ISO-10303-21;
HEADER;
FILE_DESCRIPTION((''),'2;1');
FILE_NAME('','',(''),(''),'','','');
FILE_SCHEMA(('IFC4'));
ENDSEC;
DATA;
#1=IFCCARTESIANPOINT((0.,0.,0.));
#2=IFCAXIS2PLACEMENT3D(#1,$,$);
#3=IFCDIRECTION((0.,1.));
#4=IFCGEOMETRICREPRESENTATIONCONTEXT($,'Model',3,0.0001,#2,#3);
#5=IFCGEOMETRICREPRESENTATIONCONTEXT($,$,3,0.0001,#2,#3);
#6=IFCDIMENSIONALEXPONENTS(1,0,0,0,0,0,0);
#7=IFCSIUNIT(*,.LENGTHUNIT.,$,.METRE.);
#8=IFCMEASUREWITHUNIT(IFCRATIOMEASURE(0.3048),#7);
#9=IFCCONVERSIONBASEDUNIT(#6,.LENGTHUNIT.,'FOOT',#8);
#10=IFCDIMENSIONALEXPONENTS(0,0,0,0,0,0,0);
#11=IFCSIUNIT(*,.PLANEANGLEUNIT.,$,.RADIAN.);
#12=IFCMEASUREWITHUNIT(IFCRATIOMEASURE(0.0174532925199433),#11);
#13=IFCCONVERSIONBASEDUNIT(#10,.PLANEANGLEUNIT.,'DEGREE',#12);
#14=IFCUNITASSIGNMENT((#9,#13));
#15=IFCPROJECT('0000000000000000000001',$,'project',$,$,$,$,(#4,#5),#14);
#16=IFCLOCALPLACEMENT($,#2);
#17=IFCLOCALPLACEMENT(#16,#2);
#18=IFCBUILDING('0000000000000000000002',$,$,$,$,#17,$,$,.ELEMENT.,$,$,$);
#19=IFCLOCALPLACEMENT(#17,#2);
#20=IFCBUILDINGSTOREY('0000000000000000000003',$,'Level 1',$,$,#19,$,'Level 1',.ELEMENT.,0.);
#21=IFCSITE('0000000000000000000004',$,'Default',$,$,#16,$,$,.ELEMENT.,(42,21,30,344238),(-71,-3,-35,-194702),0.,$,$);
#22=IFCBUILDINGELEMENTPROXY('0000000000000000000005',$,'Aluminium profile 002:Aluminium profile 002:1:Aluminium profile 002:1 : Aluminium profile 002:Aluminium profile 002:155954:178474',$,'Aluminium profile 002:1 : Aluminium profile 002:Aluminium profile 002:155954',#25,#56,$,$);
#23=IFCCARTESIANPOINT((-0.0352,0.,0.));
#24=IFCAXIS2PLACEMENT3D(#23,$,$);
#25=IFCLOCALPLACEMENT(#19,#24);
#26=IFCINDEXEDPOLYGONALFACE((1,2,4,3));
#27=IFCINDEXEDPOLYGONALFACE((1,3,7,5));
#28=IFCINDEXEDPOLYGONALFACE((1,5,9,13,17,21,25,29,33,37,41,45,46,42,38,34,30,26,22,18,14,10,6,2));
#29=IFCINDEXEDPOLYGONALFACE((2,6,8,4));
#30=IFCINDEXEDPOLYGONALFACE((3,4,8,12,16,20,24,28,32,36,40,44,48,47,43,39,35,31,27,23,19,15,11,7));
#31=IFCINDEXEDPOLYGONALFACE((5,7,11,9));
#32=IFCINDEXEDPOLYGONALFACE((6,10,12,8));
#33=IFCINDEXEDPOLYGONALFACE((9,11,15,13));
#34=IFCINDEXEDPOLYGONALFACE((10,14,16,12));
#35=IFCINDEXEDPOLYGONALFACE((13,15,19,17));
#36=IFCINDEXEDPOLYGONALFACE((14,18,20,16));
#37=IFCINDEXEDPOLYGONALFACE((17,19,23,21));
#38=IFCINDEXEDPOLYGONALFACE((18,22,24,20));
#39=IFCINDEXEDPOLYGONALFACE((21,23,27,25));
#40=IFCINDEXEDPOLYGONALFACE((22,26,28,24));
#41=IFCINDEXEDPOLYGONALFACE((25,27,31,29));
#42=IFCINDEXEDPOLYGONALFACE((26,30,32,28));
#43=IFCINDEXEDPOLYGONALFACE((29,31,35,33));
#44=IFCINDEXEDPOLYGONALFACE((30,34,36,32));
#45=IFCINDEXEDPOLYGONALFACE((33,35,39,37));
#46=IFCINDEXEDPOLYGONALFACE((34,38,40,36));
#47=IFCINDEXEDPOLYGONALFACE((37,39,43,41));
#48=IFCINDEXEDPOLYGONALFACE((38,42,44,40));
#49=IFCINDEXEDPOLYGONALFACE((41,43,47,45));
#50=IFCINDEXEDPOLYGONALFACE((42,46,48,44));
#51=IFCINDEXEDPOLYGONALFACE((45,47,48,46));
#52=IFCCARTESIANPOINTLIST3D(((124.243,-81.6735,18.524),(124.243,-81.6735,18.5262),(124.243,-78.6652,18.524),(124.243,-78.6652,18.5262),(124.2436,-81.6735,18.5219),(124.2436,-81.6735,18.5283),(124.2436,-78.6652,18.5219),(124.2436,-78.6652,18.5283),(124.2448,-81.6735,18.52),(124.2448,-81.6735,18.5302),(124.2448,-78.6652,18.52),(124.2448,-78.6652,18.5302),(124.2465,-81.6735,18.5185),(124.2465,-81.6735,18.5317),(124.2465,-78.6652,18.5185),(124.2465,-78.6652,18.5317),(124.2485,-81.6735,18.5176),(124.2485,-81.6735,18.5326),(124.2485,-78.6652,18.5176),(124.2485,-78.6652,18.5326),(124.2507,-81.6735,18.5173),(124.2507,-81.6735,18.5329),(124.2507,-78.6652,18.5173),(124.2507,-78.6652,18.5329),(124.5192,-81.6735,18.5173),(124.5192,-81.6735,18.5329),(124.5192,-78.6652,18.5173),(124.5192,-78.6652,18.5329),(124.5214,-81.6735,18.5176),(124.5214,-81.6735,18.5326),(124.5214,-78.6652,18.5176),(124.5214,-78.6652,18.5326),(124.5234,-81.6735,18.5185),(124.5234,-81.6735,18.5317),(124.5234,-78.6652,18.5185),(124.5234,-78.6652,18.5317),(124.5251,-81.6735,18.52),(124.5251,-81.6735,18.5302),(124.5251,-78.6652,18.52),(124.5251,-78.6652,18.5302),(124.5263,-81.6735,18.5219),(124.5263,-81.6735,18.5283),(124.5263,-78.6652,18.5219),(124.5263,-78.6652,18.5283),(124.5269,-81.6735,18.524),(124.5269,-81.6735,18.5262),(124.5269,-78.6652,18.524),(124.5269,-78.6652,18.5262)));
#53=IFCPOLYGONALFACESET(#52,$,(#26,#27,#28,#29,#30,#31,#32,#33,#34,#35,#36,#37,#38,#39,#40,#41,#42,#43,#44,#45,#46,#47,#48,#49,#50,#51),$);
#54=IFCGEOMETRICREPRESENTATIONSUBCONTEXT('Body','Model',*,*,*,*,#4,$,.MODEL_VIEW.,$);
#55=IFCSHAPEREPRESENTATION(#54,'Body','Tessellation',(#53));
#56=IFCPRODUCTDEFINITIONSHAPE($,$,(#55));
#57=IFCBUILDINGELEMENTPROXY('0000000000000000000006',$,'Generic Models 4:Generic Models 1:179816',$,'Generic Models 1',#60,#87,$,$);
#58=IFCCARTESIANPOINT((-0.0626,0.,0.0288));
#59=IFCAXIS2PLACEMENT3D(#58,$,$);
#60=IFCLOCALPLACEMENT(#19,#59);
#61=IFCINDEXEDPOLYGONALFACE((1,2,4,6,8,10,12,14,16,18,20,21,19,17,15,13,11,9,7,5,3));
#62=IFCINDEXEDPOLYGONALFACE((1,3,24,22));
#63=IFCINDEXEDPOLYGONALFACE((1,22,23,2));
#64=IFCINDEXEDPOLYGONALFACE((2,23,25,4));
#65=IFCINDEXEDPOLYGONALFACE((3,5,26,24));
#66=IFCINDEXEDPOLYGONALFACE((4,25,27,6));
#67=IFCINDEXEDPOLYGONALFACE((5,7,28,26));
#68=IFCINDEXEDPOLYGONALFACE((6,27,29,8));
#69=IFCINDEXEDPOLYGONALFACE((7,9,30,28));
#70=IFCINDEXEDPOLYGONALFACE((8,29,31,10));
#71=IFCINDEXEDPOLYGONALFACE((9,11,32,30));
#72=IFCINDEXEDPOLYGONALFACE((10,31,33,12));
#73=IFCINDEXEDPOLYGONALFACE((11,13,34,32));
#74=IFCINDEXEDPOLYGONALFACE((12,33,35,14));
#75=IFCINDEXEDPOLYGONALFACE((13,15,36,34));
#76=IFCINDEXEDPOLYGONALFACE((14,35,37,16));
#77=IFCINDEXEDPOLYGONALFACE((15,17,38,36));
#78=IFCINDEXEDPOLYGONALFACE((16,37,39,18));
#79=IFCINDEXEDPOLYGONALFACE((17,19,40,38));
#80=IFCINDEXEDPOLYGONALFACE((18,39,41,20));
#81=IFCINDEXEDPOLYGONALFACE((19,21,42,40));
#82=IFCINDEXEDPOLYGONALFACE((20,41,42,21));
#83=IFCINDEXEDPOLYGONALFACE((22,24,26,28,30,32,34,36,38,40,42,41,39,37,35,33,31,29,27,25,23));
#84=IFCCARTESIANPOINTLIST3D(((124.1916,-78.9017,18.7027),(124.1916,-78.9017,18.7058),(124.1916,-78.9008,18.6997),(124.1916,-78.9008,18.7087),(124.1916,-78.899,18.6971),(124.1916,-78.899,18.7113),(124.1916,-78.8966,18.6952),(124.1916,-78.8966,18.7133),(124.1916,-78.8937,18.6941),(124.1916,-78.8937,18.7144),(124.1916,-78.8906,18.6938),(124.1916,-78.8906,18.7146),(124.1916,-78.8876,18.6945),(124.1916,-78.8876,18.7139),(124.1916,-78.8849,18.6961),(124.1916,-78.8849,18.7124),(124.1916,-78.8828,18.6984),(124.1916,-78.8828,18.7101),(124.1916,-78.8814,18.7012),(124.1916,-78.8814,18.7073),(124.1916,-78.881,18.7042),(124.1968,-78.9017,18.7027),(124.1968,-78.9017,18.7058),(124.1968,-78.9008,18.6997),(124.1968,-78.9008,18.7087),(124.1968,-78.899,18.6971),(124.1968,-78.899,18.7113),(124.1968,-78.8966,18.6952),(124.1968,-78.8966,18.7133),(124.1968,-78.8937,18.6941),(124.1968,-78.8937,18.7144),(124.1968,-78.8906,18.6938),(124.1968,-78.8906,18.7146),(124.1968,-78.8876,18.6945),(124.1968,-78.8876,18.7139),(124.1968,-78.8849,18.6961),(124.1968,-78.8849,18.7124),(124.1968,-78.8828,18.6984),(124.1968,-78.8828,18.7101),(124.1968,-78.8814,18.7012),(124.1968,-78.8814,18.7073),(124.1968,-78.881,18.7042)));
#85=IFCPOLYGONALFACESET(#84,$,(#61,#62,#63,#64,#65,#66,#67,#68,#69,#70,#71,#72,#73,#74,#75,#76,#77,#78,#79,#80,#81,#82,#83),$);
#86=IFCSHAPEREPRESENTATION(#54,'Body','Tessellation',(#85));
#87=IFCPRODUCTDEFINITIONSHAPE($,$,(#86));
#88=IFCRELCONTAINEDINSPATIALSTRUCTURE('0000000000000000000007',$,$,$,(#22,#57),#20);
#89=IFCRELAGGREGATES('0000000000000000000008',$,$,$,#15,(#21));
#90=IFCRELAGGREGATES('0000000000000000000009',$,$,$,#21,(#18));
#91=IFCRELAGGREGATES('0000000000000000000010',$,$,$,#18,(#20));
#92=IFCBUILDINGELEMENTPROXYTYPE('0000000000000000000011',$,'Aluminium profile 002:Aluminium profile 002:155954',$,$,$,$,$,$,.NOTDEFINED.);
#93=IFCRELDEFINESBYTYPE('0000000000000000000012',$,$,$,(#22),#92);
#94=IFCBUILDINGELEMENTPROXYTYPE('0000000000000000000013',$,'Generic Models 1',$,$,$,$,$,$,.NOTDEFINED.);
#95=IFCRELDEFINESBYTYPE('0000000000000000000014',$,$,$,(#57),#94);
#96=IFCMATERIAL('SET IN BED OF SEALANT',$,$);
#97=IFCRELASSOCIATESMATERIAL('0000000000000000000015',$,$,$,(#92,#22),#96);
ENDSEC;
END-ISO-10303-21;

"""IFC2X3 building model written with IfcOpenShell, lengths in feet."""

from ifc_helpers import new_model, entity, si_unit, converted_unit, direction, frame, frame_2d, origin, origin_2d_with_axis, place, context, subcontext, project, spatial, polyline, circle_curve, parameter, trimmed, segment, composite_curve, circle, outline, extrude, source, transform, mapped, material, type_object, type_shapes, element, save


model = new_model("IFC2X3")

# Units and contexts
model_context = context("Model", 3, precision=0.0001, world=origin(), true_north=direction((0.0, 1.0)))
context_of_model = context(None, 3, precision=0.0001, world=origin(), true_north=direction((0.0, 1.0)))
body_context = subcontext(model_context, "Body", "Model", "MODEL_VIEW")
ifc_project = project(units=[converted_unit("LENGTHUNIT", "FOOT", entity("IfcRatioMeasure", 0.3048), si_unit("LENGTHUNIT", "METRE"), dimensions=[1, 0, 0, 0, 0, 0, 0]), converted_unit("PLANEANGLEUNIT", "DEGREE", entity("IfcRatioMeasure", 0.0174532925199433), si_unit("PLANEANGLEUNIT", "RADIAN"), dimensions=[0, 0, 0, 0, 0, 0, 0])], contexts=[model_context, context_of_model])

# Site, building, storey
site_placement = place(None, origin())
site = spatial("IfcSite", under=ifc_project, at=site_placement, Name="Default", CompositionType="ELEMENT", RefLatitude=(42, 21, 30, 344238), RefLongitude=(-71, -3, -35, -194702), RefElevation=0.0)
building_placement = place(site_placement, origin())
building = spatial("IfcBuilding", under=site, at=building_placement, CompositionType="ELEMENT")
storey_placement = place(building_placement, origin())
storey = spatial("IfcBuildingStorey", under=building, at=storey_placement, Name="Level 1", LongName="Level 1", CompositionType="ELEMENT", Elevation=0.0)

# Building element proxies
ifc_material_1 = material(Name="SET IN BED OF SEALANT")
building_element_proxy_type_1 = type_object("IfcBuildingElementProxyType", Name="Aluminium profile 002:Aluminium profile 002:155954", PredefinedType="NOTDEFINED", material=ifc_material_1)
shared_shape_1 = source(origin(), body_context, "Body", "SweptSolid", [
    extrude(outline(composite_curve([segment(polyline([(-0.1342, -0.0078), (0.1342, -0.0078)]), True, "CONTINUOUS"), segment(trimmed(circle_curve(frame_2d((0.1342, 0.0), x_axis=(-1.0, 0.0)), 0.0078), [parameter(90.0)], [parameter(270.0)], True, "PARAMETER"), True, "CONTINUOUS"), segment(polyline([(0.1342, 0.0078), (-0.1342, 0.0078)]), True, "CONTINUOUS"), segment(trimmed(circle_curve(frame_2d((-0.1342, 0.0), x_axis=(-1.0, 0.0)), 0.0078), [parameter(270.0)], [parameter(90.0)], True, "PARAMETER"), True, "CONTINUOUS")], self_intersect=False)), frame((124.3849, -81.6735, 18.5251), z_axis=(0.0, 1.0, 0.0), x_axis=(-1.0, 0.0, 0.0)), (0.0, 0.0, 1.0), 3.0083),
])
type_shapes(building_element_proxy_type_1, [shared_shape_1])
proxy_1_placement = place(storey_placement, frame((-0.0352, 0.0, 0.0)))
element("IfcBuildingElementProxy", 1, at=proxy_1_placement, inside=storey, type_object=building_element_proxy_type_1, material=ifc_material_1, Name="Aluminium profile 002:Aluminium profile 002:1:Aluminium profile 002:1 : Aluminium profile 002:Aluminium profile 002:155954:178474", ObjectType="Aluminium profile 002:1 : Aluminium profile 002:Aluminium profile 002:155954", context=body_context, shape_type="MappedRepresentation", body=[
    mapped(shared_shape_1, transform((0.0, 0.0, 0.0), scale=1.0)),
])
building_element_proxy_type_2 = type_object("IfcBuildingElementProxyType", Name="Generic Models 1", PredefinedType="NOTDEFINED")
shared_shape_2 = source(origin(), body_context, "Body", "SweptSolid", [
    extrude(circle(Radius=0.0104, at=origin_2d_with_axis()), frame((124.1916, -78.8914, 18.7042), z_axis=(1.0, 0.0, 0.0), x_axis=(0.0, 1.0, 0.0)), (0.0, 0.0, 1.0), 0.0052),
])
type_shapes(building_element_proxy_type_2, [shared_shape_2])
proxy_2_placement = place(storey_placement, frame((-0.0626, 0.0, 0.0288)))
element("IfcBuildingElementProxy", 2, at=proxy_2_placement, inside=storey, type_object=building_element_proxy_type_2, Name="Generic Models 4:Generic Models 1:179816", ObjectType="Generic Models 1", context=body_context, shape_type="MappedRepresentation", body=[
    mapped(shared_shape_2, transform((0.0, 0.0, 0.0), scale=1.0)),
])

save(model, "model.ifc")
